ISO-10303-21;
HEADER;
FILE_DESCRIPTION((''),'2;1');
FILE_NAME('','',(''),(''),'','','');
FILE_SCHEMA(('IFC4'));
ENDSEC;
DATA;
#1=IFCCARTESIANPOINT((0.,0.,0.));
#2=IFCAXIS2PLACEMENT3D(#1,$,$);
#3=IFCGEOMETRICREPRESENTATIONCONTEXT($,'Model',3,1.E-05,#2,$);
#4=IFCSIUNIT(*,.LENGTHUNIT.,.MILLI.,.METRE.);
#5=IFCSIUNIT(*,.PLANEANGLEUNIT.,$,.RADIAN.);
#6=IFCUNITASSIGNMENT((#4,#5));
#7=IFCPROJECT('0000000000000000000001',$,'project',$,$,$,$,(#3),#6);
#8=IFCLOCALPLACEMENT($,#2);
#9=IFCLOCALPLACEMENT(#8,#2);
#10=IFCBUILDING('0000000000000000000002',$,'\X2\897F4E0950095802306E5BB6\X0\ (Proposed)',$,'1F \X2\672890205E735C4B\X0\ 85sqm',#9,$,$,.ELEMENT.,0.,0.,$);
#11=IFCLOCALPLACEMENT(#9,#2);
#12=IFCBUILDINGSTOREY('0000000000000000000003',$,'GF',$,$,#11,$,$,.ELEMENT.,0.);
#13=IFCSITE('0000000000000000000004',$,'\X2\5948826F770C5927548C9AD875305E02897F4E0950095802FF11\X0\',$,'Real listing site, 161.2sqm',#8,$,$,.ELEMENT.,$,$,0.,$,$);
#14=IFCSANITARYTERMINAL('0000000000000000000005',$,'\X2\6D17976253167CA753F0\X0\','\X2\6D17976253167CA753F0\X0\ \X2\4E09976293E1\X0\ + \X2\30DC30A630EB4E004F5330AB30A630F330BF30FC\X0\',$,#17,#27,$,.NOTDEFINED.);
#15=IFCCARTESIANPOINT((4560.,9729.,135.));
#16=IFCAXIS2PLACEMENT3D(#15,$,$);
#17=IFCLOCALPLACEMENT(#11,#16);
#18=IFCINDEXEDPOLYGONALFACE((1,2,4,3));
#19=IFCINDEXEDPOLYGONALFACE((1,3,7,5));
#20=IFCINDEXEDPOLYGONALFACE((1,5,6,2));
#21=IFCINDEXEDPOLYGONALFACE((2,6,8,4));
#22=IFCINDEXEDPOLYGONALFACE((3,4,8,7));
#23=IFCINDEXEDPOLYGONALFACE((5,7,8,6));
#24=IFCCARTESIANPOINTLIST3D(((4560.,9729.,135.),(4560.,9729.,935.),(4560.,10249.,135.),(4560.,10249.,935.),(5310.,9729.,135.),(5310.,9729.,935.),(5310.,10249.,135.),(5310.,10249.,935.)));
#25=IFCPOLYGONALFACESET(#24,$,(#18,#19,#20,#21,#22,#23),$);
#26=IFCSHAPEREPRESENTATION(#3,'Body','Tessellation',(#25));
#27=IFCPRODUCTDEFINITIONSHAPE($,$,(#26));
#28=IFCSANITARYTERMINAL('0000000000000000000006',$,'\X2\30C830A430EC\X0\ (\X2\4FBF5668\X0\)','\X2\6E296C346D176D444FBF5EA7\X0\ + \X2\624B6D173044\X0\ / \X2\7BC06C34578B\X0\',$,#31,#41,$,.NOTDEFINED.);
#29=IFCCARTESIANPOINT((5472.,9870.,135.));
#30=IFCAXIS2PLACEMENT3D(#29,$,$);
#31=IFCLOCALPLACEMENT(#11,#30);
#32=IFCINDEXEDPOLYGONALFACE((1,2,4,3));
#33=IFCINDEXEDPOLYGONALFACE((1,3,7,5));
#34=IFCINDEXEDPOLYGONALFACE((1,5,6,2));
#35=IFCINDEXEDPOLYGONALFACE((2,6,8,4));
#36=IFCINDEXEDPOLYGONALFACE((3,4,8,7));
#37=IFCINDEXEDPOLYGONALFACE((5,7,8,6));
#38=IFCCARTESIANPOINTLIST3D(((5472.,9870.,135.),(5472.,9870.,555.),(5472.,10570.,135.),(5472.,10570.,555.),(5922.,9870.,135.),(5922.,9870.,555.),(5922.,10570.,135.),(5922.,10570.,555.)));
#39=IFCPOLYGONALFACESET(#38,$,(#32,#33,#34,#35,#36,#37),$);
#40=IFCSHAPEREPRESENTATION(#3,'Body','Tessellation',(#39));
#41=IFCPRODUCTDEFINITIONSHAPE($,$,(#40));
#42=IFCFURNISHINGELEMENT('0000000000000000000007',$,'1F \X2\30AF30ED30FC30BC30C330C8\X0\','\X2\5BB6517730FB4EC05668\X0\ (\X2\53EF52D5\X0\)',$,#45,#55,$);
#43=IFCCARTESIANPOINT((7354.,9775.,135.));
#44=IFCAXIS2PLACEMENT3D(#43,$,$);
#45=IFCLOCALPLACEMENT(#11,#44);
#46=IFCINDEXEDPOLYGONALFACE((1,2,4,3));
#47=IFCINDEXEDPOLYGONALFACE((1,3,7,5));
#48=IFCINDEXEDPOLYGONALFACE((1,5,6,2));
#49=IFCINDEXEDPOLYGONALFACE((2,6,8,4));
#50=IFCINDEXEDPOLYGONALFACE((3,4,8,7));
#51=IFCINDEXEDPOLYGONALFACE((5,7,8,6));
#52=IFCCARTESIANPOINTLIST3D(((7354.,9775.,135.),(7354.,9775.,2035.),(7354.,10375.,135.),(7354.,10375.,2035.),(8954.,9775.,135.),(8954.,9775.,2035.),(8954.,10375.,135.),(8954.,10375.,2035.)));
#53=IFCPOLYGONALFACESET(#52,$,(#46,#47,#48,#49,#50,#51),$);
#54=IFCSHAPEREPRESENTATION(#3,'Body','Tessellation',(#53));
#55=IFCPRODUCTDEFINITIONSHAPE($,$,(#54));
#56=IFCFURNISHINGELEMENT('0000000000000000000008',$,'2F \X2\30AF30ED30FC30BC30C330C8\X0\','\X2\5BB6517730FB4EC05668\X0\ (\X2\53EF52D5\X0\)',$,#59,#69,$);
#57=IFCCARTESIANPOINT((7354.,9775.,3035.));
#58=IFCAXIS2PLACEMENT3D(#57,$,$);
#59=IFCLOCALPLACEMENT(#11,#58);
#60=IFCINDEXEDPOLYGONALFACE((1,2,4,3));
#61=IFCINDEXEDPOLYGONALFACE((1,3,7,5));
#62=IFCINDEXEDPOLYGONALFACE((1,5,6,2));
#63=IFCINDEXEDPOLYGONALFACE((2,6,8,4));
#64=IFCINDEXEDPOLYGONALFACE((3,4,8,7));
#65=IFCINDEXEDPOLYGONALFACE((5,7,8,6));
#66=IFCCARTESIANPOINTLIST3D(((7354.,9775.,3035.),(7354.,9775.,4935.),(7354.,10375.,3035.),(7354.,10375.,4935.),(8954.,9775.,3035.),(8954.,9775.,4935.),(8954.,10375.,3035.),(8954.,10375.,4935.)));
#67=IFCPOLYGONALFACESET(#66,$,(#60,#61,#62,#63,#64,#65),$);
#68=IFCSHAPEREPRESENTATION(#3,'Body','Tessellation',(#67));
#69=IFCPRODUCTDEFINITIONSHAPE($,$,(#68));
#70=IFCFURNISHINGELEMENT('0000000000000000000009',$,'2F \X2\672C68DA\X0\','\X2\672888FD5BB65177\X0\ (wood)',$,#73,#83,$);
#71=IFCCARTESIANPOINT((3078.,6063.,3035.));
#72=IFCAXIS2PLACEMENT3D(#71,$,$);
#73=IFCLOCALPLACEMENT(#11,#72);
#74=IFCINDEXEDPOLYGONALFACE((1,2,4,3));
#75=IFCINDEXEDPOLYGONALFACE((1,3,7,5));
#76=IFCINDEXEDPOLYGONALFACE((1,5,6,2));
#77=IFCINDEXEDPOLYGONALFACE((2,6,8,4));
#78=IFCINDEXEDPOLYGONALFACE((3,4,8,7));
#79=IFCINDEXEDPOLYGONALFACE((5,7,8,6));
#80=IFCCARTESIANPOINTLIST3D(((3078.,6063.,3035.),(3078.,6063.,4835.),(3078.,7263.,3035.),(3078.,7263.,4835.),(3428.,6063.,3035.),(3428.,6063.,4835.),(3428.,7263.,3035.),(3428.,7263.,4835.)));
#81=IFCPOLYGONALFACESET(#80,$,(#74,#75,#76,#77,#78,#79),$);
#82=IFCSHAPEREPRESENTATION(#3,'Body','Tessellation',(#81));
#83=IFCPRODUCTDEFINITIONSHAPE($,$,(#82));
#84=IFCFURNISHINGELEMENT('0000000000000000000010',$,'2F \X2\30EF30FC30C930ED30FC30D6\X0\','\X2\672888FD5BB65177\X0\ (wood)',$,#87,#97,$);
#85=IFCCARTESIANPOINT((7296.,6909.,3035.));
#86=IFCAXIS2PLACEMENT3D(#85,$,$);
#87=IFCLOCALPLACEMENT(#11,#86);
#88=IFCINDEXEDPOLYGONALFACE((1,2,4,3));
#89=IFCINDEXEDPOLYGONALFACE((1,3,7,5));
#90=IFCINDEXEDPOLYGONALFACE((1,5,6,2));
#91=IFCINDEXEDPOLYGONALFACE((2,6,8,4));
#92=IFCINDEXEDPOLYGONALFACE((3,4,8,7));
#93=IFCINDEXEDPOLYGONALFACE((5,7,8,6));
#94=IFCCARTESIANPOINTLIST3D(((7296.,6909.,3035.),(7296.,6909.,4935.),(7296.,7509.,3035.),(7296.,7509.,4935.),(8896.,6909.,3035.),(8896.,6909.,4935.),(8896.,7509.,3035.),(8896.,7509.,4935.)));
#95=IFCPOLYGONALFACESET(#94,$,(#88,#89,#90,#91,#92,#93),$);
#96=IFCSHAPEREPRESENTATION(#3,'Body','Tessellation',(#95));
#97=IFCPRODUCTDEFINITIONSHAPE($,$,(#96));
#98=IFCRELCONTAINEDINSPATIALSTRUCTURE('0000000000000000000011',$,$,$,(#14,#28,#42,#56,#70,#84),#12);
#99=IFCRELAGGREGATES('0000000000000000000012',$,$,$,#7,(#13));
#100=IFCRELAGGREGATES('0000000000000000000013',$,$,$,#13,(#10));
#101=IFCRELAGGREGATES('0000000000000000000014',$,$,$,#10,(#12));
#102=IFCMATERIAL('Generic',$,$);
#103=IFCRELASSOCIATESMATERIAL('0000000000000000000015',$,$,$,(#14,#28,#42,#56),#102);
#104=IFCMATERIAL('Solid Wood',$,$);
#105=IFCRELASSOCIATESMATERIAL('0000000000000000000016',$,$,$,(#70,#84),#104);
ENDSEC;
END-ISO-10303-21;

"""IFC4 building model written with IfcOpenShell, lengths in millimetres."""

from ifc_helpers import new_model, si_unit, frame, frame_2d, origin, place, context, project, spatial, rectangle, extrude, material, element, save


model = new_model("IFC4")

# Units and contexts
model_context = context("Model", 3, precision=1e-05, world=origin())
ifc_project = project(units=[si_unit("LENGTHUNIT", "METRE", prefix="MILLI"), si_unit("PLANEANGLEUNIT", "RADIAN")], contexts=[model_context])

# Site, building, storey
site_placement = place(None, origin())
site = spatial("IfcSite", under=ifc_project, at=site_placement, Name="奈良県大和高田市西三倉堂１", ObjectType="Real listing site, 161.2sqm", CompositionType="ELEMENT", RefElevation=0.0)
building_placement = place(site_placement, origin())
building = spatial("IfcBuilding", under=site, at=building_placement, Name="西三倉堂の家 (Proposed)", ObjectType="1F 木造平屋 85sqm", CompositionType="ELEMENT", ElevationOfRefHeight=0.0, ElevationOfTerrain=0.0)
storey_placement = place(building_placement, origin())
storey = spatial("IfcBuildingStorey", under=building, at=storey_placement, Name="GF", CompositionType="ELEMENT", Elevation=0.0)

# Shared definitions
ifc_material_1 = material(Name="Solid Wood")

# Shared definitions
ifc_material_2 = material(Name="Generic")

# Sanitary terminals
sanitary_terminal_1_placement = place(storey_placement, frame((4560.0, 9729.0, 135.0)))
element("IfcSanitaryTerminal", 1, at=sanitary_terminal_1_placement, inside=storey, material=ifc_material_2, Name="洗面化粧台", Description="洗面化粧台 三面鏡 + ボウル一体カウンター", PredefinedType="NOTDEFINED", context=model_context, shape_type="SweptSolid", body=[
    extrude(rectangle(XDim=750.0, YDim=520.0, at=frame_2d((375.0, 260.0))), frame((4560.0, 9729.0, 135.0)), (0.0, 0.0, 1.0), 800.0),
])
sanitary_terminal_2_placement = place(storey_placement, frame((5472.0, 9870.0, 135.0)))
element("IfcSanitaryTerminal", 2, at=sanitary_terminal_2_placement, inside=storey, material=ifc_material_2, Name="トイレ (便器)", Description="温水洗浄便座 + 手洗い / 節水型", PredefinedType="NOTDEFINED", context=model_context, shape_type="SweptSolid", body=[
    extrude(rectangle(XDim=450.0, YDim=700.0, at=frame_2d((225.0, 350.0))), frame((5472.0, 9870.0, 135.0)), (0.0, 0.0, 1.0), 420.0),
])

# Furnishing elements
furnishing_1_placement = place(storey_placement, frame((7354.0, 9775.0, 135.0)))
element("IfcFurnishingElement", 3, at=furnishing_1_placement, inside=storey, material=ifc_material_2, Name="1F クローゼット", Description="家具・什器 (可動)", context=model_context, shape_type="SweptSolid", body=[
    extrude(rectangle(XDim=1600.0, YDim=600.0, at=frame_2d((800.0, 300.0))), frame((7354.0, 9775.0, 135.0)), (0.0, 0.0, 1.0), 1900.0),
])
furnishing_2_placement = place(storey_placement, frame((7354.0, 9775.0, 3035.0)))
element("IfcFurnishingElement", 4, at=furnishing_2_placement, inside=storey, material=ifc_material_2, Name="2F クローゼット", Description="家具・什器 (可動)", context=model_context, shape_type="SweptSolid", body=[
    extrude(rectangle(XDim=1600.0, YDim=600.0, at=frame_2d((800.0, 300.0))), frame((7354.0, 9775.0, 3035.0)), (0.0, 0.0, 1.0), 1900.0),
])
furnishing_3_placement = place(storey_placement, frame((3078.0, 6063.0, 3035.0)))
element("IfcFurnishingElement", 5, at=furnishing_3_placement, inside=storey, material=ifc_material_1, Name="2F 本棚", Description="木製家具 (wood)", context=model_context, shape_type="SweptSolid", body=[
    extrude(rectangle(XDim=350.0, YDim=1200.0, at=frame_2d((175.0, 600.0))), frame((3078.0, 6063.0, 3035.0)), (0.0, 0.0, 1.0), 1800.0),
])
furnishing_4_placement = place(storey_placement, frame((7296.0, 6909.0, 3035.0)))
element("IfcFurnishingElement", 6, at=furnishing_4_placement, inside=storey, material=ifc_material_1, Name="2F ワードローブ", Description="木製家具 (wood)", context=model_context, shape_type="SweptSolid", body=[
    extrude(rectangle(XDim=1600.0, YDim=600.0, at=frame_2d((800.0, 300.0))), frame((7296.0, 6909.0, 3035.0)), (0.0, 0.0, 1.0), 1900.0),
])

save(model, "model.ifc")
